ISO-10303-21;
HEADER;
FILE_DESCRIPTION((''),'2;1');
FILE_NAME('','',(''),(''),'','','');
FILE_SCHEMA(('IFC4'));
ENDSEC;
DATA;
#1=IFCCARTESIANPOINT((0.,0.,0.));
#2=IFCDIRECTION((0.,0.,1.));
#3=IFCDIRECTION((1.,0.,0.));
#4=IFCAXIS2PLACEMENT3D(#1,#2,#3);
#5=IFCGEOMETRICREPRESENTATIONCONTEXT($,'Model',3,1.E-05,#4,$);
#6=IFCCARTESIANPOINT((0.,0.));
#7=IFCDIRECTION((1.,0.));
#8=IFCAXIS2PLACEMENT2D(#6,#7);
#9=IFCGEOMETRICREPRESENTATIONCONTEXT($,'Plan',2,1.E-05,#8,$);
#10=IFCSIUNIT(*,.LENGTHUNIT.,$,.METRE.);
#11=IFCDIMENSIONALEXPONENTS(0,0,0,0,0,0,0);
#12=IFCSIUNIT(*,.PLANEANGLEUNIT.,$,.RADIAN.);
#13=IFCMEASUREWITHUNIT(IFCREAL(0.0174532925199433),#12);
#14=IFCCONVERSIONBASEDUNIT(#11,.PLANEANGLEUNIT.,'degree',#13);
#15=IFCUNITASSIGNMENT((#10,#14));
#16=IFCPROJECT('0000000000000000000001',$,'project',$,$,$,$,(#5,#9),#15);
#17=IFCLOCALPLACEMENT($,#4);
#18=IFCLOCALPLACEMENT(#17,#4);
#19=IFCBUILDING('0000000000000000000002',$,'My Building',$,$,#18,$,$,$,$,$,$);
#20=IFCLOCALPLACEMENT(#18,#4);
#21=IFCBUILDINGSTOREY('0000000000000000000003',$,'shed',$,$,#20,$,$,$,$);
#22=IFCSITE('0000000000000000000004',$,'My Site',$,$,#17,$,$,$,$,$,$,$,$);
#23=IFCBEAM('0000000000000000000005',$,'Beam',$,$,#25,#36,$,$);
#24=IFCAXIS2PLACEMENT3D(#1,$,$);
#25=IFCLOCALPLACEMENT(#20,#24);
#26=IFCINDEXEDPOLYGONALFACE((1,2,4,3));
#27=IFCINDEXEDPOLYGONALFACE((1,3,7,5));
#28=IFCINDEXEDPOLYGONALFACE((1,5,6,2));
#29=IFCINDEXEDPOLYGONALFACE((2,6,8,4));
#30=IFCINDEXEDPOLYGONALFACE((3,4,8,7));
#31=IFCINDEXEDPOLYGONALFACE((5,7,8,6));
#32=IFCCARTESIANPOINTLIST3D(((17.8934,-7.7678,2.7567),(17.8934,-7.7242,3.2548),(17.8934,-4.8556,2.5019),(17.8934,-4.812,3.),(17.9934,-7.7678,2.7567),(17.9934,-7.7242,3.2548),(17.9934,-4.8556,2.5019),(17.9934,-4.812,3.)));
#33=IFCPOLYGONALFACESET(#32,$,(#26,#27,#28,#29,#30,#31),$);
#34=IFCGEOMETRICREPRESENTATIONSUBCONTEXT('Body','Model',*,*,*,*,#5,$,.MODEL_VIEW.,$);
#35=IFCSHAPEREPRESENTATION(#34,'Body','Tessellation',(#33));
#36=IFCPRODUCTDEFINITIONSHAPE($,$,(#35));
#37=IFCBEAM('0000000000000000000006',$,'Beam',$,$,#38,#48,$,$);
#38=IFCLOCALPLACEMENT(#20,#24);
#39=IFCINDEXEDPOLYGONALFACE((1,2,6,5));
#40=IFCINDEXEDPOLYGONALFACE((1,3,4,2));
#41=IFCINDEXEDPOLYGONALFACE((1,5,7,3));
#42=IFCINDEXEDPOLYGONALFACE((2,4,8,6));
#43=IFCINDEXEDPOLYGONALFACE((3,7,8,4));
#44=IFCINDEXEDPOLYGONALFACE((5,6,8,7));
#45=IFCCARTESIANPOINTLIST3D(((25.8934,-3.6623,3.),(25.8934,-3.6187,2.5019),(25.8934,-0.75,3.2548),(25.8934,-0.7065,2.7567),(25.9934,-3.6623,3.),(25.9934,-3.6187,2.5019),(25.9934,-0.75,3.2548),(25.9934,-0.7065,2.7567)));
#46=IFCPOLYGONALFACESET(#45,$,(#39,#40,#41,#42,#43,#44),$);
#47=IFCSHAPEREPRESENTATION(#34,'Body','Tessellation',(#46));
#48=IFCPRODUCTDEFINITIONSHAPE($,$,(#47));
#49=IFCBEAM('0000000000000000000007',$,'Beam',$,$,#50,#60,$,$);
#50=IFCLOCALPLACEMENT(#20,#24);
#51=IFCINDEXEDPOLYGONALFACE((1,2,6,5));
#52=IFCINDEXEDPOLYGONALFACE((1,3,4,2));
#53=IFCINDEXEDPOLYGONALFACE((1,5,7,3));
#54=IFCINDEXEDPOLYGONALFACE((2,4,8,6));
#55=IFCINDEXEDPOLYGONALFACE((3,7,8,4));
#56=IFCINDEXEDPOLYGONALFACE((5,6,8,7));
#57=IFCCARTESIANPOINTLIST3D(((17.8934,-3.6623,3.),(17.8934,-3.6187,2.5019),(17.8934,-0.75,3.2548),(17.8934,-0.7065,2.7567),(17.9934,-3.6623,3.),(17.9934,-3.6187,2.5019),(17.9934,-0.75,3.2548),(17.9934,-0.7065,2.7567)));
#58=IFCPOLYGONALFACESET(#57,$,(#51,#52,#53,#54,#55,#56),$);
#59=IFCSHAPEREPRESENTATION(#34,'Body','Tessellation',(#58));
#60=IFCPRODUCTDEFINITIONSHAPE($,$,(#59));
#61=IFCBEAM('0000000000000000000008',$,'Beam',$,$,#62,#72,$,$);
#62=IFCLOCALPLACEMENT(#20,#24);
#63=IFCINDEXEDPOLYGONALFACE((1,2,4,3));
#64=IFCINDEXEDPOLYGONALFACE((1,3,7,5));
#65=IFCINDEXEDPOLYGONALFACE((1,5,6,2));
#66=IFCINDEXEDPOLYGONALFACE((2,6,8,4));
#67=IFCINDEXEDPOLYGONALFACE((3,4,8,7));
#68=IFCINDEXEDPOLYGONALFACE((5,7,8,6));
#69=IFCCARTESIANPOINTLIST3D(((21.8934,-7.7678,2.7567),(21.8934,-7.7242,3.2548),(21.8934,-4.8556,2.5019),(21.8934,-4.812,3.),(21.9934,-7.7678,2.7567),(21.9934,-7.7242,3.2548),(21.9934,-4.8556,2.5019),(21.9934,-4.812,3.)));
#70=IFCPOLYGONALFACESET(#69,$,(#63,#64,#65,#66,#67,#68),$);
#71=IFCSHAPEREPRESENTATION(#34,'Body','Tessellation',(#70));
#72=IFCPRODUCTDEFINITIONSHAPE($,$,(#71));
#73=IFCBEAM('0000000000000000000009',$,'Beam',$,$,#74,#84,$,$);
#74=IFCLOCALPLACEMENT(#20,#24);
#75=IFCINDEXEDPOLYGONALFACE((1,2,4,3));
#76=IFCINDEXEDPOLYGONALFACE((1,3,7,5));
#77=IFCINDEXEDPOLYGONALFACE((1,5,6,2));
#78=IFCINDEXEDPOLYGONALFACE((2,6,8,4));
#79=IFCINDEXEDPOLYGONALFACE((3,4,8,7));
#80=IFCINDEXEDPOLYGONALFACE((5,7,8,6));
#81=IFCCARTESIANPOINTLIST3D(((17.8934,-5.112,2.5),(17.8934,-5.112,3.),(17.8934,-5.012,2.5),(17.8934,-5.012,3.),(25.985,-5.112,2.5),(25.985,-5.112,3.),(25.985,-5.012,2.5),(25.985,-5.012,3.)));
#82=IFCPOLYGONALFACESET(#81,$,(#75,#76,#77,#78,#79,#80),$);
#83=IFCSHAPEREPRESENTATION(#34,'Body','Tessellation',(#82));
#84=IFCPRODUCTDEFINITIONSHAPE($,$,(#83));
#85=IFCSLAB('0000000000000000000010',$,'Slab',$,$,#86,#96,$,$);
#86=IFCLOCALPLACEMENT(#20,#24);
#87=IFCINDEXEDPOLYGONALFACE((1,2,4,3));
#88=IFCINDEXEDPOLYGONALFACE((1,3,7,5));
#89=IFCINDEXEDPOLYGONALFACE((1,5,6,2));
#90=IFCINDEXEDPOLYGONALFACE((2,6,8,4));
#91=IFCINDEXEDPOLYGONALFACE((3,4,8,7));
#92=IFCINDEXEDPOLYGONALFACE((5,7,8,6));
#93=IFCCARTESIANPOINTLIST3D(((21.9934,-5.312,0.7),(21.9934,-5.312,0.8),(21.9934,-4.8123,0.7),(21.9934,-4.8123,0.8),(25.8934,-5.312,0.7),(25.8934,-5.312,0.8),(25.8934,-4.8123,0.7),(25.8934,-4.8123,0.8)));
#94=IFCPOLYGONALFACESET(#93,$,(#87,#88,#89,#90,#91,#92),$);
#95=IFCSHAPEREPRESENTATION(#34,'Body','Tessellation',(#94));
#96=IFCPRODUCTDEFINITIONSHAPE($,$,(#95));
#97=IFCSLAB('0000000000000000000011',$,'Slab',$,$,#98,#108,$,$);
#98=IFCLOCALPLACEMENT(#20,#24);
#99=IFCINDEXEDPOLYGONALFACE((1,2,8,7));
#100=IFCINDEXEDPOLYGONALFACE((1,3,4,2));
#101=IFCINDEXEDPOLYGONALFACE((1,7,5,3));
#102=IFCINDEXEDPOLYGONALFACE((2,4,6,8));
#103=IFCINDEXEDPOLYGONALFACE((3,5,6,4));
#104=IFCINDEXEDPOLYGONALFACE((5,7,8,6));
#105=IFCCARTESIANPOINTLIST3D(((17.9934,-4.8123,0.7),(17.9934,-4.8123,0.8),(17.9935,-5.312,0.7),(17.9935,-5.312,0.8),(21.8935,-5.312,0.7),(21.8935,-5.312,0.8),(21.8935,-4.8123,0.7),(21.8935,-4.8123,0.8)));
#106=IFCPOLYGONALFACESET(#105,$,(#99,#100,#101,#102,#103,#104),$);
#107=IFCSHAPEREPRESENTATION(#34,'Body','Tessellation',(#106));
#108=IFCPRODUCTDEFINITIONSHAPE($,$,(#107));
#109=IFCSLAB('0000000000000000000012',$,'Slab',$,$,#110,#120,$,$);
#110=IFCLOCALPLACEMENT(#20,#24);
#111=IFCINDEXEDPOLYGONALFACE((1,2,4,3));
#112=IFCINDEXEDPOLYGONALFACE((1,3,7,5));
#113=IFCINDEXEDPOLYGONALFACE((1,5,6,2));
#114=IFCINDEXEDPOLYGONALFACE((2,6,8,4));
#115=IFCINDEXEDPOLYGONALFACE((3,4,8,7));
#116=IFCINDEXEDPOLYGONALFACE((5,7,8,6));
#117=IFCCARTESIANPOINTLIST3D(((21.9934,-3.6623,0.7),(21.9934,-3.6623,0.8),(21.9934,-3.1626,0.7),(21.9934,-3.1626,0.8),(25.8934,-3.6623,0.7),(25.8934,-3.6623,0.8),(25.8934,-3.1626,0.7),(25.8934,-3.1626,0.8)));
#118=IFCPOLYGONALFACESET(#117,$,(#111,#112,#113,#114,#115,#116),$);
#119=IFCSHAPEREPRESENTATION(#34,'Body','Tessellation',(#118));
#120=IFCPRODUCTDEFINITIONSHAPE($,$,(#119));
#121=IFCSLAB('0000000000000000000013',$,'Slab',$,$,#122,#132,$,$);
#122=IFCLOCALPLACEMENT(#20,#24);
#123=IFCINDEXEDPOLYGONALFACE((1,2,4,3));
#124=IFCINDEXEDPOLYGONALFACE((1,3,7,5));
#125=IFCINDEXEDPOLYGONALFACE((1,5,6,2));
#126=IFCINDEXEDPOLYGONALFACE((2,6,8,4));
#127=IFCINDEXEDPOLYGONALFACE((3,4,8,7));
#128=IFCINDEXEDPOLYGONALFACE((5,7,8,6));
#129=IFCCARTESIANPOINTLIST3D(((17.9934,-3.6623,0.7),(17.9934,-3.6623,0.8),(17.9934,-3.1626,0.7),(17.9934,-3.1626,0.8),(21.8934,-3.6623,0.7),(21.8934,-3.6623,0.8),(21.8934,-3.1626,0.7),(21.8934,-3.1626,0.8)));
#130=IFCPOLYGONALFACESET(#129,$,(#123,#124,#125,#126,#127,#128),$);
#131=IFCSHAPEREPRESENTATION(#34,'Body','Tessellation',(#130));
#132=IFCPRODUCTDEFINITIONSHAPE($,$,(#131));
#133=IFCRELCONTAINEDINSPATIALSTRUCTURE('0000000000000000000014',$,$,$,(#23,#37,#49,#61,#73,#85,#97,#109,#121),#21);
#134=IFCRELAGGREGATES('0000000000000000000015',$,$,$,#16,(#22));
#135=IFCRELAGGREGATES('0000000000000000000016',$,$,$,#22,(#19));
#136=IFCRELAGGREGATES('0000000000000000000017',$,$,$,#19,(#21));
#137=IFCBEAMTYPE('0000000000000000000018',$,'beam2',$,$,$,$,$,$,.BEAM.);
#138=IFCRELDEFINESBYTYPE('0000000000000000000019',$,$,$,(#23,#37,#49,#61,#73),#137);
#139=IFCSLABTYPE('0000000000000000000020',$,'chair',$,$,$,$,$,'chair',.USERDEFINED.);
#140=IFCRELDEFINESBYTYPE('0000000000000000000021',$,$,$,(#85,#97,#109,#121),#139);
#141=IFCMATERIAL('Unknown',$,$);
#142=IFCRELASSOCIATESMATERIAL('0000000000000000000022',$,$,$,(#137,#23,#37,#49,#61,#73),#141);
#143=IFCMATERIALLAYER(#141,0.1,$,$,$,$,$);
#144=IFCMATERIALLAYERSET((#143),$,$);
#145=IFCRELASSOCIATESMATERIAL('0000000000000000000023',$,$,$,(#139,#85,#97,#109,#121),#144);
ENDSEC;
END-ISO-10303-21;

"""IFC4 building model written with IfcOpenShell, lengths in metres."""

from ifc_helpers import new_model, entity, si_unit, converted_unit, frame, origin_with_axes, origin_2d_with_axis, place, context, subcontext, project, spatial, indexed_curve, rectangle, outline, extrude, material, layer, layer_set, layer_usage, material_profile, profile_set, profile_usage, type_object, element, save


model = new_model("IFC4")

# Units and contexts
model_context = context("Model", 3, precision=1e-05, world=origin_with_axes())
plan_context = context("Plan", 2, precision=1e-05, world=origin_2d_with_axis())
body_context = subcontext(model_context, "Body", "Model", "MODEL_VIEW")
ifc_project = project(units=[si_unit("LENGTHUNIT", "METRE"), converted_unit("PLANEANGLEUNIT", "degree", entity("IfcReal", 0.0174532925199433), si_unit("PLANEANGLEUNIT", "RADIAN"), dimensions=[0, 0, 0, 0, 0, 0, 0])], contexts=[model_context, plan_context])

# Site, building, storey
site_placement = place(None, origin_with_axes())
site = spatial("IfcSite", under=ifc_project, at=site_placement, Name="My Site")
building_placement = place(site_placement, origin_with_axes())
building = spatial("IfcBuilding", under=site, at=building_placement, Name="My Building")
storey_placement = place(building_placement, origin_with_axes())
storey = spatial("IfcBuildingStorey", under=building, at=storey_placement, Name="shed")

# Shared definitions
ifc_material = material(Name="Unknown")

# Beams
ifc_material_profile_1 = material_profile(ifc_material, rectangle(XDim=0.1, YDim=0.5))
ifc_profile_set_1 = profile_set([ifc_material_profile_1])
beam_type = type_object("IfcBeamType", Name="beam2", PredefinedType="BEAM", material=ifc_profile_set_1)
ifc_profile_usage_1 = profile_usage(ifc_profile_set_1, cardinal=8)
beam_1_placement = place(storey_placement, frame((17.9434, -4.812, 3.0), z_axis=(0.0, -0.996195, 0.087156), x_axis=(1.0, 0.0, 0.0)))
element("IfcBeam", 1, at=beam_1_placement, inside=storey, type_object=beam_type, material=ifc_profile_usage_1, Name="Beam", context=body_context, shape_type="SweptSolid", body=[
    extrude(rectangle(XDim=0.1, YDim=0.5), frame((0.0, -0.25, 0.0), z_axis=(0.0, 0.0, 1.0), x_axis=(1.0, 0.0, 0.0)), (0.0, 0.0, 1.0), 2.9234),
])
ifc_profile_usage_2 = profile_usage(ifc_profile_set_1, cardinal=8)
beam_2_placement = place(storey_placement, frame((25.9434, -3.6623, 3.0), z_axis=(0.0, 0.996195, 0.087156), x_axis=(-1.0, 0.0, 0.0)))
element("IfcBeam", 2, at=beam_2_placement, inside=storey, type_object=beam_type, material=ifc_profile_usage_2, Name="Beam", context=body_context, shape_type="SweptSolid", body=[
    extrude(rectangle(XDim=0.1, YDim=0.5), frame((0.0, -0.25, 0.0), z_axis=(0.0, 0.0, 1.0), x_axis=(1.0, 0.0, 0.0)), (0.0, 0.0, 1.0), 2.9234),
])
ifc_profile_usage_3 = profile_usage(ifc_profile_set_1, cardinal=8)
beam_3_placement = place(storey_placement, frame((17.9434, -3.6623, 3.0), z_axis=(0.0, 0.996195, 0.087156), x_axis=(-1.0, 0.0, 0.0)))
element("IfcBeam", 3, at=beam_3_placement, inside=storey, type_object=beam_type, material=ifc_profile_usage_3, Name="Beam", context=body_context, shape_type="SweptSolid", body=[
    extrude(rectangle(XDim=0.1, YDim=0.5), frame((0.0, -0.25, 0.0), z_axis=(0.0, 0.0, 1.0), x_axis=(1.0, 0.0, 0.0)), (0.0, 0.0, 1.0), 2.9234),
])
ifc_profile_usage_4 = profile_usage(ifc_profile_set_1, cardinal=8)
beam_4_placement = place(storey_placement, frame((21.9434, -4.812, 3.0), z_axis=(0.0, -0.996195, 0.087156), x_axis=(1.0, 0.0, 0.0)))
element("IfcBeam", 4, at=beam_4_placement, inside=storey, type_object=beam_type, material=ifc_profile_usage_4, Name="Beam", context=body_context, shape_type="SweptSolid", body=[
    extrude(rectangle(XDim=0.1, YDim=0.5), frame((0.0, -0.25, 0.0), z_axis=(0.0, 0.0, 1.0), x_axis=(1.0, 0.0, 0.0)), (0.0, 0.0, 1.0), 2.9234),
])
ifc_profile_usage_5 = profile_usage(ifc_profile_set_1, cardinal=8)
beam_5_placement = place(storey_placement, frame((17.8934, -5.062, 3.0), z_axis=(1.0, -0.000001, 0.000001), x_axis=(0.000001, 1.0, 0.0)))
element("IfcBeam", 5, at=beam_5_placement, inside=storey, type_object=beam_type, material=ifc_profile_usage_5, Name="Beam", context=body_context, shape_type="SweptSolid", body=[
    extrude(rectangle(XDim=0.1, YDim=0.5), frame((0.0, -0.25, 0.0), z_axis=(0.0, 0.0, 1.0), x_axis=(1.0, 0.0, 0.0)), (0.0, 0.0, 1.0), 8.0916),
])

# Slabs
ifc_layer = layer(ifc_material, 0.1)
ifc_layer_set = layer_set([ifc_layer])
ifc_layer_usage_1 = layer_usage(ifc_layer_set, "AXIS3", "POSITIVE", -0.1)
slab_type = type_object("IfcSlabType", Name="chair", ElementType="chair", PredefinedType="USERDEFINED", material=ifc_layer_set)
slab_1_placement = place(storey_placement, frame((21.9934, -5.312, 0.8), z_axis=(0.0, 0.0, 1.0), x_axis=(1.0, 0.0, 0.0)))
element("IfcSlab", 6, at=slab_1_placement, inside=storey, type_object=slab_type, material=ifc_layer_usage_1, Name="Slab", context=body_context, shape_type="SweptSolid", body=[
    extrude(outline(indexed_curve([(0.0, 0.0), (3.9, 0.0), (3.9, 0.4997), (0.0, 0.4997), (0.0, 0.0)])), frame((0.0, 0.0, -0.1), z_axis=(0.0, 0.0, 1.0), x_axis=(1.0, 0.0, 0.0)), (0.0, 0.0, 1.0), 0.1),
])
ifc_layer_usage_2 = layer_usage(ifc_layer_set, "AXIS3", "POSITIVE", -0.1)
slab_2_placement = place(storey_placement, frame((17.9935, -5.312, 0.8), z_axis=(0.0, 0.0, 1.0), x_axis=(1.0, 0.0, 0.0)))
element("IfcSlab", 7, at=slab_2_placement, inside=storey, type_object=slab_type, material=ifc_layer_usage_2, Name="Slab", context=body_context, shape_type="SweptSolid", body=[
    extrude(outline(indexed_curve([(0.0, 0.0), (3.9, 0.0), (3.9, 0.4997), (0.0, 0.4997), (0.0, 0.0)])), frame((0.0, 0.0, -0.1), z_axis=(0.0, 0.0, 1.0), x_axis=(1.0, 0.0, 0.0)), (0.0, 0.0, 1.0), 0.1),
])
ifc_layer_usage_3 = layer_usage(ifc_layer_set, "AXIS3", "POSITIVE", -0.1)
slab_3_placement = place(storey_placement, frame((21.9934, -3.6623, 0.8), z_axis=(0.0, 0.0, 1.0), x_axis=(1.0, 0.0, 0.0)))
element("IfcSlab", 8, at=slab_3_placement, inside=storey, type_object=slab_type, material=ifc_layer_usage_3, Name="Slab", context=body_context, shape_type="SweptSolid", body=[
    extrude(outline(indexed_curve([(0.0, 0.0), (3.9, 0.0), (3.9, 0.4997), (0.0, 0.4997), (0.0, 0.0)])), frame((0.0, 0.0, -0.1), z_axis=(0.0, 0.0, 1.0), x_axis=(1.0, 0.0, 0.0)), (0.0, 0.0, 1.0), 0.1),
])
ifc_layer_usage_4 = layer_usage(ifc_layer_set, "AXIS3", "POSITIVE", -0.1)
slab_4_placement = place(storey_placement, frame((17.9934, -3.6623, 0.8), z_axis=(0.0, 0.0, 1.0), x_axis=(1.0, 0.0, 0.0)))
element("IfcSlab", 9, at=slab_4_placement, inside=storey, type_object=slab_type, material=ifc_layer_usage_4, Name="Slab", context=body_context, shape_type="SweptSolid", body=[
    extrude(outline(indexed_curve([(0.0, 0.0), (3.9, 0.0), (3.9, 0.4997), (0.0, 0.4997), (0.0, 0.0)])), frame((0.0, 0.0, -0.1), z_axis=(0.0, 0.0, 1.0), x_axis=(1.0, 0.0, 0.0)), (0.0, 0.0, 1.0), 0.1),
])

save(model, "model.ifc")
